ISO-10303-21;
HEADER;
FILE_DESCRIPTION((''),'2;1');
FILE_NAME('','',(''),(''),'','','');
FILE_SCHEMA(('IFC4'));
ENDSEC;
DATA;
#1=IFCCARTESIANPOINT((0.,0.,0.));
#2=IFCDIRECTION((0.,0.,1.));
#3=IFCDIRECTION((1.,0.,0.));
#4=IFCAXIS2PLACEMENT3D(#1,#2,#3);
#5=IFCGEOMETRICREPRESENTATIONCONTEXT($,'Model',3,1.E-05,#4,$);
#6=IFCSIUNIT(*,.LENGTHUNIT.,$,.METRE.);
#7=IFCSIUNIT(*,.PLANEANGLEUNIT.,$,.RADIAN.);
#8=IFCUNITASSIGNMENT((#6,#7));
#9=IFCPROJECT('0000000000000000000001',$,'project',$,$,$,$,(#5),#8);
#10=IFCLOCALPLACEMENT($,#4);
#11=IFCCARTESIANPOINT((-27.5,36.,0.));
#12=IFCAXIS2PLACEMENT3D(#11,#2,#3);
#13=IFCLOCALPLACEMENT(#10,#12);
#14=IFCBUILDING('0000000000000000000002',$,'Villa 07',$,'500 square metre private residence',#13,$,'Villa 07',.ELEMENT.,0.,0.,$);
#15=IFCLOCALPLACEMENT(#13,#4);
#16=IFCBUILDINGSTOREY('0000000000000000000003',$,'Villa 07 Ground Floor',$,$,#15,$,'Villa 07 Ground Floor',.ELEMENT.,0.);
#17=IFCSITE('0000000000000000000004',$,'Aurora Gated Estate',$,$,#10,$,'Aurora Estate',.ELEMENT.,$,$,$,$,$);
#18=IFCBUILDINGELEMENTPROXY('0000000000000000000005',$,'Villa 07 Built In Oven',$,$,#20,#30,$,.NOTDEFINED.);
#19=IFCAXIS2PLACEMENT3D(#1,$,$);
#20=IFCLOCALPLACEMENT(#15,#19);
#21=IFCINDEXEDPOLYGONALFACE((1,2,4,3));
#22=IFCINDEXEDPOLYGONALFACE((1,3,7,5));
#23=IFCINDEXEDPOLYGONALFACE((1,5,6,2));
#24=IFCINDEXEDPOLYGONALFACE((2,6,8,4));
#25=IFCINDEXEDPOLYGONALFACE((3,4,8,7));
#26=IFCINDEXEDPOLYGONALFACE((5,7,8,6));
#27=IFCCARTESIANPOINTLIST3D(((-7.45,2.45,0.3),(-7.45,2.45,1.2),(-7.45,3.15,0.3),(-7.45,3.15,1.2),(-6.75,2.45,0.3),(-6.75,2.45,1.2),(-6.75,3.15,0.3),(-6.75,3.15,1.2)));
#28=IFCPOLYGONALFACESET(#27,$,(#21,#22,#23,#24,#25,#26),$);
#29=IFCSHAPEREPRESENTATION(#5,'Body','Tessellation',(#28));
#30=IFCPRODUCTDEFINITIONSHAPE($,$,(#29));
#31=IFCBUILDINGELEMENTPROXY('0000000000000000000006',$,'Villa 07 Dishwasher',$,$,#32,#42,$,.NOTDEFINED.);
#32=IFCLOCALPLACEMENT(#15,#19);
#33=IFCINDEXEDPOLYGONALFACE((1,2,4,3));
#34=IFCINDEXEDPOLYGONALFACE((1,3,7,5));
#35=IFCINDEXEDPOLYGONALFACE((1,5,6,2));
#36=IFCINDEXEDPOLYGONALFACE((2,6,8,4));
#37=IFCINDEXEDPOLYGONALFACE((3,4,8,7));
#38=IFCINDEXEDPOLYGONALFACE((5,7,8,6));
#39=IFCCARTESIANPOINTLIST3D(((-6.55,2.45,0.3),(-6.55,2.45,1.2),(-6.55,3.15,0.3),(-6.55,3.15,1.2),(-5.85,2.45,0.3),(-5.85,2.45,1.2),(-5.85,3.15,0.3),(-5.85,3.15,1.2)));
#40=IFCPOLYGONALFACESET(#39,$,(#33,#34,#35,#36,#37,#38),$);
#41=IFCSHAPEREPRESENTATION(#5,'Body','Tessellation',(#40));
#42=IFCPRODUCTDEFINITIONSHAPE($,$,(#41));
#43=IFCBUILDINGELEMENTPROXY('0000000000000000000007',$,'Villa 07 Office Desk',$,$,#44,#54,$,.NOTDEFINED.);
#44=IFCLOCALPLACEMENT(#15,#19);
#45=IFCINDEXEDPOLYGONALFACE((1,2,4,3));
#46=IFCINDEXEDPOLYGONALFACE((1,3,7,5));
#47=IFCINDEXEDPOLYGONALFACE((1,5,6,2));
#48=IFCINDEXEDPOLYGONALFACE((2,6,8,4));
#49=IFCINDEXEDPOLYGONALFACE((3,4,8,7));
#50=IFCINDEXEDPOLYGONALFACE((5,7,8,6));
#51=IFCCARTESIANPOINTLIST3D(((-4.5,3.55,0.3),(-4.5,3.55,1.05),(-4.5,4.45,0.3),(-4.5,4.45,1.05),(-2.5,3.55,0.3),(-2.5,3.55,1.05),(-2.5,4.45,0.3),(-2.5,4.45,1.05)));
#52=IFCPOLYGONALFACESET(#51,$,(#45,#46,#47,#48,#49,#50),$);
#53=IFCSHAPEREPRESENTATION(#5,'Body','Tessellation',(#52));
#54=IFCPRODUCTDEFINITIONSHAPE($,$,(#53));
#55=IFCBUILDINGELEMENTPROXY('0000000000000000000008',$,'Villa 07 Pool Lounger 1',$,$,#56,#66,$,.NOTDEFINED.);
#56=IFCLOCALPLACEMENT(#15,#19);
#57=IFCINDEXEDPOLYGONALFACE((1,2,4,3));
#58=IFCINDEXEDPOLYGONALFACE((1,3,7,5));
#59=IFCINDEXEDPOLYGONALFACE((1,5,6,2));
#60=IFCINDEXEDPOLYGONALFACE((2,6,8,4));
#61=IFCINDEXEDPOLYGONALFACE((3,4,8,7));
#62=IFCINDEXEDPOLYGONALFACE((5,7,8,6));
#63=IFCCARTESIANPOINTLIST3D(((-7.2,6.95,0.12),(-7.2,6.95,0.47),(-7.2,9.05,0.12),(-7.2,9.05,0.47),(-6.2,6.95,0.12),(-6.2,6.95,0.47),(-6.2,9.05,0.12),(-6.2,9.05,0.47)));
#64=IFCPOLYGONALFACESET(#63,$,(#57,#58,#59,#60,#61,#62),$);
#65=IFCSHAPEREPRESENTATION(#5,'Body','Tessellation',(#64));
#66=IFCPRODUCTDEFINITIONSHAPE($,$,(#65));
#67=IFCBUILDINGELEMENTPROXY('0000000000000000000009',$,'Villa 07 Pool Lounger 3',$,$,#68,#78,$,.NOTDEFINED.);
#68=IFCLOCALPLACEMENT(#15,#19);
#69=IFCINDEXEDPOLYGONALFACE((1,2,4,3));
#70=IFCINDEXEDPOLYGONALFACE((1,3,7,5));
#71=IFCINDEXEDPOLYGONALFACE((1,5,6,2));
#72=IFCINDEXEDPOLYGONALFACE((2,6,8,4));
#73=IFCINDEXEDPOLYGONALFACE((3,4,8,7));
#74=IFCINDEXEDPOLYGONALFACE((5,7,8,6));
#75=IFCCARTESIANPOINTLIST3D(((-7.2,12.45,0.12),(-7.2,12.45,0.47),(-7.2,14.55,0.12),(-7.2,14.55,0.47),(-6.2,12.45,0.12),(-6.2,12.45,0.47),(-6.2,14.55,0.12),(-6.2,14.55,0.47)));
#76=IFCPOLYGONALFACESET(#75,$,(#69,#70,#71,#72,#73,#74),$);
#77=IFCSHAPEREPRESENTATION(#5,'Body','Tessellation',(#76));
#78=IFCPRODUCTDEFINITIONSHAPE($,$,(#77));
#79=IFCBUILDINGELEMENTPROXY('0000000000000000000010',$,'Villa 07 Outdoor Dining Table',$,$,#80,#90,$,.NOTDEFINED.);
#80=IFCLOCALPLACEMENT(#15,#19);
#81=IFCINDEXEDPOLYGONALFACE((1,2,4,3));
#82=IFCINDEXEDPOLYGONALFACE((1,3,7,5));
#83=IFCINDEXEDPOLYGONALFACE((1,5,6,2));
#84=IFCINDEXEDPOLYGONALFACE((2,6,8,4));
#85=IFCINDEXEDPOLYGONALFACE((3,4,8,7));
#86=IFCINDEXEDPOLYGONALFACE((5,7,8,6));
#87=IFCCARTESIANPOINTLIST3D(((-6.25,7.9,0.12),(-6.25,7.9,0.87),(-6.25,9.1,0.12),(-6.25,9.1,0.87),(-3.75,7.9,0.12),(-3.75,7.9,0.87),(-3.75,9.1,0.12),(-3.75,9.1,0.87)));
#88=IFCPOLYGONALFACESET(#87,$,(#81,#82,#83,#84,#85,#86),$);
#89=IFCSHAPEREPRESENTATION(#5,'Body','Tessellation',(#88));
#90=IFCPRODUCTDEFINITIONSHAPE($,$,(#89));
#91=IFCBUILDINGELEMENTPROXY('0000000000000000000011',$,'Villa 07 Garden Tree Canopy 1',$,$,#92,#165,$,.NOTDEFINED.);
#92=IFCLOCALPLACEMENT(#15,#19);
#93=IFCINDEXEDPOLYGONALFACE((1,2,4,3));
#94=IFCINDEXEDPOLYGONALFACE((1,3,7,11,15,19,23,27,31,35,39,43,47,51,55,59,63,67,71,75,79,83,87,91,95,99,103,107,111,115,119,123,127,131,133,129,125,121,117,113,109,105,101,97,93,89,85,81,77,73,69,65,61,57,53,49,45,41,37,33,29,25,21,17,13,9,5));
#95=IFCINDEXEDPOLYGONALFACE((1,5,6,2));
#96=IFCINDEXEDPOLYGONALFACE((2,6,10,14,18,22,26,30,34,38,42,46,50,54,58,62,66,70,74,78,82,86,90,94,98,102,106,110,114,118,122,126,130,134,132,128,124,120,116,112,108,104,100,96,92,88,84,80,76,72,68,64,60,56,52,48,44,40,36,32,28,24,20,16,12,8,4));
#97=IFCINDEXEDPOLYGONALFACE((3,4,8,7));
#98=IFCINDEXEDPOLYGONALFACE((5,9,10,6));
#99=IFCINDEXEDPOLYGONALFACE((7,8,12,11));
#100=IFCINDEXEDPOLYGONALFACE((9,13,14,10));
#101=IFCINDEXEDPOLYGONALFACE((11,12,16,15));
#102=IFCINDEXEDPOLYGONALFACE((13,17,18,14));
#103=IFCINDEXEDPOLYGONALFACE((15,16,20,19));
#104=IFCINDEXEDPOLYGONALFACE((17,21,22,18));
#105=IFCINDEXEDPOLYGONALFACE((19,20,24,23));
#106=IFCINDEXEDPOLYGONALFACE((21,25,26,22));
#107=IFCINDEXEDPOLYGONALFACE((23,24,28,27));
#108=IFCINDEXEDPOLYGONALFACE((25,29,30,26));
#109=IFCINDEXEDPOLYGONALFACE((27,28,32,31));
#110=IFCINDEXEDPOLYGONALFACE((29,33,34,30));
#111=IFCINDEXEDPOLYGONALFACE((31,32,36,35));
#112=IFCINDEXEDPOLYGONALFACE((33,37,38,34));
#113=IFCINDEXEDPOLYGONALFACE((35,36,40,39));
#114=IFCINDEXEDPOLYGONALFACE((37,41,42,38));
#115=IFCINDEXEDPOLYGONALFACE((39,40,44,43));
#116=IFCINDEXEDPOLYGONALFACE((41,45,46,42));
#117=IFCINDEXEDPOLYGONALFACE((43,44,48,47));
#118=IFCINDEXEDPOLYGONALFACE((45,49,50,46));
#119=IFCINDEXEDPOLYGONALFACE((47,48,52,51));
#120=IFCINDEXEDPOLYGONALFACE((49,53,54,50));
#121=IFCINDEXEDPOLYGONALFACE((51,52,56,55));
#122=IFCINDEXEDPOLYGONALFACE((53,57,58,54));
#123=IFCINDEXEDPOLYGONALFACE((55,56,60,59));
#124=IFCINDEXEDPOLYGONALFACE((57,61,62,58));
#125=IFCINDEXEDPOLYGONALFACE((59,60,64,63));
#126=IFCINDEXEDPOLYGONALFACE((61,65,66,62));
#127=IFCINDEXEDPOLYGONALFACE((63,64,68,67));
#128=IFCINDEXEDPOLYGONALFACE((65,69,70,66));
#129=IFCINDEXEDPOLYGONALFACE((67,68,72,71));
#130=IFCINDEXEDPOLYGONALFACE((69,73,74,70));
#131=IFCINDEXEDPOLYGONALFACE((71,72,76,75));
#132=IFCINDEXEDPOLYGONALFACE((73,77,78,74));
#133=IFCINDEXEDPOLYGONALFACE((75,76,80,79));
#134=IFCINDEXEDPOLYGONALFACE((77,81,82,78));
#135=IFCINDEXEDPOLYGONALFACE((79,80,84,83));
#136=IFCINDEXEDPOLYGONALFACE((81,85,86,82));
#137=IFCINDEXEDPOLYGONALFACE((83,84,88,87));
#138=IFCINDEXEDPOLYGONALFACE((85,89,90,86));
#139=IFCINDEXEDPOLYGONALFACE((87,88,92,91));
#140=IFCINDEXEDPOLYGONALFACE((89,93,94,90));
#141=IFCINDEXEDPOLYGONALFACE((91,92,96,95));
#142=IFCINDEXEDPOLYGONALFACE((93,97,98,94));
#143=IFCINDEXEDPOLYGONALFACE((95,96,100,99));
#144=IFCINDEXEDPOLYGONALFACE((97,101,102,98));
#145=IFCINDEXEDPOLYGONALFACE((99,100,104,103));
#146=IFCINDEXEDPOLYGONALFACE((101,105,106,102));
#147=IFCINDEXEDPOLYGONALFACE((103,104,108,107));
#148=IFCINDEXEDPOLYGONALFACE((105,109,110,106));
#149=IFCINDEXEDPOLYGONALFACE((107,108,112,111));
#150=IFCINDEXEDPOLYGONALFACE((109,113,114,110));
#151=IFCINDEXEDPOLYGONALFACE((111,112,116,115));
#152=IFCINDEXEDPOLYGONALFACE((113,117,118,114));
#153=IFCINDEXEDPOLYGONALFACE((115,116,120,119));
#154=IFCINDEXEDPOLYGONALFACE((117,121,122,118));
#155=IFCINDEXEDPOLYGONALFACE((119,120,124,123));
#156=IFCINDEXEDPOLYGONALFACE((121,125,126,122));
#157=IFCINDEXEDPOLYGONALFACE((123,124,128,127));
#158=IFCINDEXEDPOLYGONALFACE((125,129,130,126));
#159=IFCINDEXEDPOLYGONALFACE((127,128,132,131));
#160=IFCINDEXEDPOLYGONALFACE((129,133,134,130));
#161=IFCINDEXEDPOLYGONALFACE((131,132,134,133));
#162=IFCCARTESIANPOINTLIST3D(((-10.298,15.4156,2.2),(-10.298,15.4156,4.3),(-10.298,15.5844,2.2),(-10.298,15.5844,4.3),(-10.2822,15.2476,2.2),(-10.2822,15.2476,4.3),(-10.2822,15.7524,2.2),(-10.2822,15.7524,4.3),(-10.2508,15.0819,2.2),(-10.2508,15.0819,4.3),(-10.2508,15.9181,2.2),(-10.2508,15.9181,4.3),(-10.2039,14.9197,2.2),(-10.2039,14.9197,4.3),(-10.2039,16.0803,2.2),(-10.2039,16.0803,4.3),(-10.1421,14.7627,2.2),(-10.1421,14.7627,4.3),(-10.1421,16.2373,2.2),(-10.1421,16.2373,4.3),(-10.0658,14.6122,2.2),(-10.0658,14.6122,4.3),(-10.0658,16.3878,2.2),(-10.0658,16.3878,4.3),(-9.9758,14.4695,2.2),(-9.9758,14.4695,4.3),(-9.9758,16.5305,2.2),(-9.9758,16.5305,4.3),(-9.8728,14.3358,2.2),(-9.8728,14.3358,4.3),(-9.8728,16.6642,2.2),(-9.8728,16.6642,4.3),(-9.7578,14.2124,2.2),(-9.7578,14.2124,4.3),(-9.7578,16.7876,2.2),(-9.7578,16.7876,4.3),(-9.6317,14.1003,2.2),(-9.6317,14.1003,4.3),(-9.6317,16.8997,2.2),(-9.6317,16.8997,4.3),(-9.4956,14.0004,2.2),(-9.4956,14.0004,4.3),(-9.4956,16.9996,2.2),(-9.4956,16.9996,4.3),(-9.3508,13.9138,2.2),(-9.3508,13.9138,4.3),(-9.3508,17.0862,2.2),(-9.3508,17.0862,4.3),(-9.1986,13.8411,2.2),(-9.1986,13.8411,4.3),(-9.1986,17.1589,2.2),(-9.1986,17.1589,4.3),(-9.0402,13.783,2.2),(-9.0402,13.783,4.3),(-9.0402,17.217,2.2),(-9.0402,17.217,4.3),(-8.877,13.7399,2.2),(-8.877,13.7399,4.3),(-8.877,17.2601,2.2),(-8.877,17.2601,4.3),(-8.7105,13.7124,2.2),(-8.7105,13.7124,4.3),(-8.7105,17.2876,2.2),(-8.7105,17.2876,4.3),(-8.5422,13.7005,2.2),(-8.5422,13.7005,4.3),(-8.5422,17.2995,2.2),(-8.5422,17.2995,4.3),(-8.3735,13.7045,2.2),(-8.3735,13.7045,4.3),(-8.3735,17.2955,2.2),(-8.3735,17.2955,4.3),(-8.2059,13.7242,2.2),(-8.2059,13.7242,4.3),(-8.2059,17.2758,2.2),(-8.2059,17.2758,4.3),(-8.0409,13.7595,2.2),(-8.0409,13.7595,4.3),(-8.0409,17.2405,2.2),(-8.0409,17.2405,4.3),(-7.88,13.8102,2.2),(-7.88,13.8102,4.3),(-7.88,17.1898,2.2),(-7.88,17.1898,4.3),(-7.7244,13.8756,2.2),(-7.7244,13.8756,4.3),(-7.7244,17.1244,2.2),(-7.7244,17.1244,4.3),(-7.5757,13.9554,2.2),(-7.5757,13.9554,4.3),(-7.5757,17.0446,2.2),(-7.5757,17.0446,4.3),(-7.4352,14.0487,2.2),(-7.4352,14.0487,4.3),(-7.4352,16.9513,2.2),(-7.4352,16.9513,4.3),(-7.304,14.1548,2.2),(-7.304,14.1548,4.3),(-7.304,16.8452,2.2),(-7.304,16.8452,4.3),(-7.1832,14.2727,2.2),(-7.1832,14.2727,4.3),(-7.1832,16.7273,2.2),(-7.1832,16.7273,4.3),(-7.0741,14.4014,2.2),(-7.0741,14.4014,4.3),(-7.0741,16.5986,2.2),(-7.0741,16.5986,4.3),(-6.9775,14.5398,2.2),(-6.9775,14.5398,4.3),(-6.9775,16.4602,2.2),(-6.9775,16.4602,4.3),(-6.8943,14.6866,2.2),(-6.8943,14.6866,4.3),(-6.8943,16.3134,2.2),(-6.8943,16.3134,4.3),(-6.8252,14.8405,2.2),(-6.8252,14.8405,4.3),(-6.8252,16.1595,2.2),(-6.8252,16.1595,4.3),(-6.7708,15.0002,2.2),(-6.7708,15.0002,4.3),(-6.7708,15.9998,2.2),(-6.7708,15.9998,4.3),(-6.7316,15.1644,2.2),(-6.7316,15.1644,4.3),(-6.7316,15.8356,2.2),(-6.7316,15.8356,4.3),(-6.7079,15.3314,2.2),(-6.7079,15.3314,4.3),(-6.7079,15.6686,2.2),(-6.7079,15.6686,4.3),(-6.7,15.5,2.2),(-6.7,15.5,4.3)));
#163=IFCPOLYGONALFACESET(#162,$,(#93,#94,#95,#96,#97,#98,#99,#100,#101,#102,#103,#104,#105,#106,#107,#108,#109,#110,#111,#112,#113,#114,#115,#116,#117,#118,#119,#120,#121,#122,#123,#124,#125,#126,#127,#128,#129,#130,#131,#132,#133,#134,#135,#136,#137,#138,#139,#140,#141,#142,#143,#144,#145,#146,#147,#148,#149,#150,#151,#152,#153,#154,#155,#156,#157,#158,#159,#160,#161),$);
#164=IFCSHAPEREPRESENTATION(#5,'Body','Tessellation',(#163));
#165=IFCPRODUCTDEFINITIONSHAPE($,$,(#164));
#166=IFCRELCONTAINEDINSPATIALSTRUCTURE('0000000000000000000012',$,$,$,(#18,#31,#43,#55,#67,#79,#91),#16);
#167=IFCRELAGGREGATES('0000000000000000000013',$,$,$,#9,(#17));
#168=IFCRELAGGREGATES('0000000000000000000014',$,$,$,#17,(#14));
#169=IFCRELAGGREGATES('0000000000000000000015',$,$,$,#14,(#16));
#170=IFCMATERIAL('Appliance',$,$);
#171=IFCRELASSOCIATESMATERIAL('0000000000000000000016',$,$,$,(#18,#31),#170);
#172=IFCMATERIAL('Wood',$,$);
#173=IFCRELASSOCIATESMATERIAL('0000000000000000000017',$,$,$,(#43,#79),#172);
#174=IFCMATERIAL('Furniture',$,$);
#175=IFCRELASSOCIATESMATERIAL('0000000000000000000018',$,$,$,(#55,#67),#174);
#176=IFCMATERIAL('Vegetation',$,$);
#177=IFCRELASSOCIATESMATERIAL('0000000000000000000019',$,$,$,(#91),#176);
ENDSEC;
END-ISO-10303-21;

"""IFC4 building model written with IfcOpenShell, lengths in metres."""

from ifc_helpers import new_model, si_unit, frame, origin_with_axes, origin_2d_with_axis, place, context, project, spatial, rectangle, circle, extrude, material, element, save


model = new_model("IFC4")

# Units and contexts
model_context = context("Model", 3, precision=1e-05, world=origin_with_axes())
ifc_project = project(units=[si_unit("LENGTHUNIT", "METRE"), si_unit("PLANEANGLEUNIT", "RADIAN")], contexts=[model_context])

# Site, building, storey
site_placement = place(None, origin_with_axes())
site = spatial("IfcSite", under=ifc_project, at=site_placement, Name="Aurora Gated Estate", LongName="Aurora Estate", CompositionType="ELEMENT")
building_placement = place(site_placement, frame((-27.5, 36.0, 0.0), z_axis=(0.0, 0.0, 1.0), x_axis=(1.0, 0.0, 0.0)))
building = spatial("IfcBuilding", under=site, at=building_placement, Name="Villa 07", ObjectType="500 square metre private residence", LongName="Villa 07", CompositionType="ELEMENT", ElevationOfRefHeight=0.0, ElevationOfTerrain=0.0)
storey_placement = place(building_placement, origin_with_axes())
storey = spatial("IfcBuildingStorey", under=building, at=storey_placement, Name="Villa 07 Ground Floor", LongName="Villa 07 Ground Floor", CompositionType="ELEMENT", Elevation=0.0)

# Shared definitions
ifc_material_1 = material(Name="Wood")

# Building element proxies
ifc_material_2 = material(Name="Appliance")
for number, where, z_axis, x_axis, name in (
    (1, (-7.1, 2.8, 0.3), (0.0, 0.0, 1.0), (1.0, 0.0, 0.0), "Villa 07 Built In Oven"),
    (2, (-6.2, 2.8, 0.3), (0.0, 0.0, 1.0), (1.0, 0.0, 0.0), "Villa 07 Dishwasher"),
):
    element("IfcBuildingElementProxy", number, at=place(storey_placement, frame(where, z_axis=z_axis, x_axis=x_axis)), inside=storey, material=ifc_material_2, Name=name, PredefinedType="NOTDEFINED", context=model_context, shape_type="SweptSolid", body=[
        extrude(rectangle(XDim=0.7, YDim=0.7, at=origin_2d_with_axis()), origin_with_axes(), (0.0, 0.0, 1.0), 0.9),
    ])
proxy_1_placement = place(storey_placement, frame((-3.5, 4.0, 0.3), z_axis=(0.0, 0.0, 1.0), x_axis=(1.0, 0.0, 0.0)))
element("IfcBuildingElementProxy", 3, at=proxy_1_placement, inside=storey, material=ifc_material_1, Name="Villa 07 Office Desk", PredefinedType="NOTDEFINED", context=model_context, shape_type="SweptSolid", body=[
    extrude(rectangle(XDim=2.0, YDim=0.9, at=origin_2d_with_axis()), origin_with_axes(), (0.0, 0.0, 1.0), 0.75),
])
ifc_material_3 = material(Name="Furniture")
for number, where, z_axis, x_axis, name in (
    (4, (-6.7, 8.0, 0.12), (0.0, 0.0, 1.0), (1.0, 0.0, 0.0), "Villa 07 Pool Lounger 1"),
    (5, (-6.7, 13.5, 0.12), (0.0, 0.0, 1.0), (1.0, 0.0, 0.0), "Villa 07 Pool Lounger 3"),
):
    element("IfcBuildingElementProxy", number, at=place(storey_placement, frame(where, z_axis=z_axis, x_axis=x_axis)), inside=storey, material=ifc_material_3, Name=name, PredefinedType="NOTDEFINED", context=model_context, shape_type="SweptSolid", body=[
        extrude(rectangle(XDim=1.0, YDim=2.1, at=origin_2d_with_axis()), origin_with_axes(), (0.0, 0.0, 1.0), 0.35),
    ])
proxy_2_placement = place(storey_placement, frame((-5.0, 8.5, 0.12), z_axis=(0.0, 0.0, 1.0), x_axis=(1.0, 0.0, 0.0)))
element("IfcBuildingElementProxy", 6, at=proxy_2_placement, inside=storey, material=ifc_material_1, Name="Villa 07 Outdoor Dining Table", PredefinedType="NOTDEFINED", context=model_context, shape_type="SweptSolid", body=[
    extrude(rectangle(XDim=2.5, YDim=1.2, at=origin_2d_with_axis()), origin_with_axes(), (0.0, 0.0, 1.0), 0.75),
])
ifc_material_4 = material(Name="Vegetation")
proxy_3_placement = place(storey_placement, frame((-8.5, 15.5, 2.2), z_axis=(0.0, 0.0, 1.0), x_axis=(1.0, 0.0, 0.0)))
element("IfcBuildingElementProxy", 7, at=proxy_3_placement, inside=storey, material=ifc_material_4, Name="Villa 07 Garden Tree Canopy 1", PredefinedType="NOTDEFINED", context=model_context, shape_type="SweptSolid", body=[
    extrude(circle(Radius=1.8, at=origin_2d_with_axis()), origin_with_axes(), (0.0, 0.0, 1.0), 2.1),
])

save(model, "model.ifc")
